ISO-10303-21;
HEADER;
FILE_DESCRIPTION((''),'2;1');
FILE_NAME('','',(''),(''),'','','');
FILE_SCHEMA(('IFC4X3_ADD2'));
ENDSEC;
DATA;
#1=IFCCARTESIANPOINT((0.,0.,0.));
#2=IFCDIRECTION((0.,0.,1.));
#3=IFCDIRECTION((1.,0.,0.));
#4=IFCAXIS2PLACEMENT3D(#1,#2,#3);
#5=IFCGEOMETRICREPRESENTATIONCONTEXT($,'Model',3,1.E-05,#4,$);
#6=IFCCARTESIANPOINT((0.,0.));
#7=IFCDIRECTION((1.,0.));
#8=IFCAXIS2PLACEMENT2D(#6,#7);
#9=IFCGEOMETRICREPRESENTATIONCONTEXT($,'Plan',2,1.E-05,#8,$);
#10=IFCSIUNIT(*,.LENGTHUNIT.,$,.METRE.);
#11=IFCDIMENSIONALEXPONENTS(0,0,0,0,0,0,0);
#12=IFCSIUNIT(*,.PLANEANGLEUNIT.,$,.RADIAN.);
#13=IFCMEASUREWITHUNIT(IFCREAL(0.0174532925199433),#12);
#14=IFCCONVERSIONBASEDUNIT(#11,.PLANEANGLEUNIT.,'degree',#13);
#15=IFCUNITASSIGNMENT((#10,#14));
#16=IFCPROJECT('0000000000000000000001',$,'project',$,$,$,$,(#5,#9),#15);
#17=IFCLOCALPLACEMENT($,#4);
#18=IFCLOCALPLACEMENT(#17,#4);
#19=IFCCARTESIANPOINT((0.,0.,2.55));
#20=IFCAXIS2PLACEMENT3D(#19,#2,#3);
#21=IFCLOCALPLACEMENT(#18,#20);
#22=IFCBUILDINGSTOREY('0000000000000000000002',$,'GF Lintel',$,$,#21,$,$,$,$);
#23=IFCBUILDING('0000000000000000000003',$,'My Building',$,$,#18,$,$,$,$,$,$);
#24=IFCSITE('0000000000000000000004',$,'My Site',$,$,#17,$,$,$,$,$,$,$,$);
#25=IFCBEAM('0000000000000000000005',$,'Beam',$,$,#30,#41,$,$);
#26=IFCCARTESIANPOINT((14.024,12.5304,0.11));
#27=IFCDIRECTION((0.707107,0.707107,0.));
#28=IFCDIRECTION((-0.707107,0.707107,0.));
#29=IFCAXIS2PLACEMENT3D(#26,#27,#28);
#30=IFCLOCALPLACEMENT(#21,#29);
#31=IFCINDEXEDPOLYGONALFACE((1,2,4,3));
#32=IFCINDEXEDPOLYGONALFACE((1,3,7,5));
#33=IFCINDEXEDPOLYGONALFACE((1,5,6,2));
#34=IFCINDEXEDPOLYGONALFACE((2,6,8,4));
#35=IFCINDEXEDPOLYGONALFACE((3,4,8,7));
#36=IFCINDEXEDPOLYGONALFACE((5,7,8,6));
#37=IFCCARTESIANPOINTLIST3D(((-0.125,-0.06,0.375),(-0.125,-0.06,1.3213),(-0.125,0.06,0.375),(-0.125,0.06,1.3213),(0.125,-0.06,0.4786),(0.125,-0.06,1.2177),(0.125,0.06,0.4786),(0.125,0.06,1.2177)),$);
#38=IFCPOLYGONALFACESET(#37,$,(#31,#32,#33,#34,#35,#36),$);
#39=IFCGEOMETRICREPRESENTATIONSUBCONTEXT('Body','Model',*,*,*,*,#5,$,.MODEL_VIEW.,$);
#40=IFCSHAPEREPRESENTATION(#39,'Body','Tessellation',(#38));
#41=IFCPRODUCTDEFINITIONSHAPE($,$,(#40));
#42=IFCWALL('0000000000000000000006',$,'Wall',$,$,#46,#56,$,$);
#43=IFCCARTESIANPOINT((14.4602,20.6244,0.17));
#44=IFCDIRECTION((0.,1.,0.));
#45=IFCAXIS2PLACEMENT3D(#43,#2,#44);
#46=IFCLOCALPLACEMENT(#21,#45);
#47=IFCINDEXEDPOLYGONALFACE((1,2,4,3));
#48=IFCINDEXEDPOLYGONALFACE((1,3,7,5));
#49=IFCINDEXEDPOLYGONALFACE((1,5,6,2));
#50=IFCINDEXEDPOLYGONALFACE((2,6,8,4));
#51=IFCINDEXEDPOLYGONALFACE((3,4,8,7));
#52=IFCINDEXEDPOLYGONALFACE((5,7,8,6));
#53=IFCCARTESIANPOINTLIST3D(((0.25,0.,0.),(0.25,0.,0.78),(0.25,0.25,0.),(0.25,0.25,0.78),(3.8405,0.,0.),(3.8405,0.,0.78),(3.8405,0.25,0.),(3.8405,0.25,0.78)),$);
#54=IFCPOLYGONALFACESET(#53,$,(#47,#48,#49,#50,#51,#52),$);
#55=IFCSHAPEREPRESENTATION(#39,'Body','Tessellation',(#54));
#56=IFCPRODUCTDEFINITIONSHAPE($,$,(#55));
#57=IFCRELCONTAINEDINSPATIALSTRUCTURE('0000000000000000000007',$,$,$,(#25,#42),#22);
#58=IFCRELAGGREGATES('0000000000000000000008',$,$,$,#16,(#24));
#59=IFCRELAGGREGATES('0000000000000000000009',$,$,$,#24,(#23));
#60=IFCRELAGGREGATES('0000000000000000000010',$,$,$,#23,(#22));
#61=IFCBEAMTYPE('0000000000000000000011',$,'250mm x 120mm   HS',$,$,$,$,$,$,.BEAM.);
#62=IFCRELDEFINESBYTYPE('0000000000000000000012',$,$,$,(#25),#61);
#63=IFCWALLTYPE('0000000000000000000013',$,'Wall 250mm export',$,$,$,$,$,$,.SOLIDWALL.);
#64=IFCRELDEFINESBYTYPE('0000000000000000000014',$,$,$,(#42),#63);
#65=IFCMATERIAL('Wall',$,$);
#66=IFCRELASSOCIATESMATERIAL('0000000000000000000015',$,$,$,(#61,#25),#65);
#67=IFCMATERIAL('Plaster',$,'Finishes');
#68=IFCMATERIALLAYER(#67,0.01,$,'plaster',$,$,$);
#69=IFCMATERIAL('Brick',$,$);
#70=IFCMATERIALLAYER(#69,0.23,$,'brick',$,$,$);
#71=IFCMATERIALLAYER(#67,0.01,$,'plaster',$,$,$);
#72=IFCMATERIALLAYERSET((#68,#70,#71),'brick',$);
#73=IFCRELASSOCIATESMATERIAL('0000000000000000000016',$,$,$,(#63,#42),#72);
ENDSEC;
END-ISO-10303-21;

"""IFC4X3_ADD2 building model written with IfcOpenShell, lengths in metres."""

from ifc_helpers import new_model, entity, si_unit, converted_unit, frame, origin_with_axes, origin_2d_with_axis, place, context, subcontext, project, spatial, line, indexed_curve, rectangle, outline, extrude, clip, halfspace, material, layer, layer_set, layer_usage, material_profile, profile_set, profile_usage, type_object, element, save


model = new_model("IFC4X3_ADD2")

# Units and contexts
model_context = context("Model", 3, precision=1e-05, world=origin_with_axes())
plan_context = context("Plan", 2, precision=1e-05, world=origin_2d_with_axis())
body_context = subcontext(model_context, "Body", "Model", "MODEL_VIEW")
ifc_project = project(units=[si_unit("LENGTHUNIT", "METRE"), converted_unit("PLANEANGLEUNIT", "degree", entity("IfcReal", 0.0174532925199433), si_unit("PLANEANGLEUNIT", "RADIAN"), dimensions=[0, 0, 0, 0, 0, 0, 0])], contexts=[model_context, plan_context])

# Site, building, storey
site_placement = place(None, origin_with_axes())
site = spatial("IfcSite", under=ifc_project, at=site_placement, Name="My Site")
building_placement = place(site_placement, origin_with_axes())
building = spatial("IfcBuilding", under=site, at=building_placement, Name="My Building")
storey_placement = place(building_placement, frame((0.0, 0.0, 2.55), z_axis=(0.0, 0.0, 1.0), x_axis=(1.0, 0.0, 0.0)))
storey = spatial("IfcBuildingStorey", under=building, at=storey_placement, Name="GF Lintel")

# Beam
ifc_material_1 = material(Name="Wall")
ifc_material_profile = material_profile(ifc_material_1, rectangle(XDim=0.25, YDim=0.12))
ifc_profile_set = profile_set([ifc_material_profile], Name="concrete")
beam_type = type_object("IfcBeamType", Name="250mm x 120mm   HS", PredefinedType="BEAM", material=ifc_profile_set)
ifc_profile_usage_1 = profile_usage(ifc_profile_set, cardinal=5)
beam_1_placement = place(storey_placement, frame((14.024, 12.5304, 0.11), z_axis=(0.707107, 0.707107, 0.0), x_axis=(-0.707107, 0.707107, 0.0)))
element("IfcBeam", 1, at=beam_1_placement, inside=storey, type_object=beam_type, material=ifc_profile_usage_1, Name="Beam", context=body_context, shape_type="Clipping", body=[
    clip(clip(extrude(rectangle(XDim=0.25, YDim=0.12), origin_with_axes(), (0.0, 0.0, 1.0), 1.6963), halfspace(frame((-0.125, -2.66, 1.3213), z_axis=(0.382685, 0.0, 0.923879), x_axis=(0.0, -1.0, 0.0)), False)), halfspace(frame((-0.125, -2.66, 0.375), z_axis=(0.382682, 0.0, -0.92388), x_axis=(0.0, -1.0, 0.0)), False)),
])

# Wall
ifc_material_2 = material(Name="Plaster", Category="Finishes")
ifc_layer_1 = layer(ifc_material_2, 0.01, Name="plaster")
ifc_material_3 = material(Name="Brick")
ifc_layer_2 = layer(ifc_material_3, 0.23, Name="brick")
ifc_layer_3 = layer(ifc_material_2, 0.01, Name="plaster")
ifc_layer_set = layer_set([ifc_layer_1, ifc_layer_2, ifc_layer_3], Name="brick")
wall_type = type_object("IfcWallType", Name="Wall 250mm export", PredefinedType="SOLIDWALL", material=ifc_layer_set)
ifc_layer_usage_1 = layer_usage(ifc_layer_set, "AXIS2", "POSITIVE", 0.0)
wall_1_placement = place(storey_placement, frame((14.4602, 20.6244, 0.17), z_axis=(0.0, 0.0, 1.0), x_axis=(0.0, 1.0, 0.0)))
element("IfcWall", 2, at=wall_1_placement, inside=storey, type_object=wall_type, material=ifc_layer_usage_1, Name="Wall", context=body_context, shape_type="SweptSolid", body=[
    extrude(outline(indexed_curve([(0.25, 0.0), (0.25, 0.25), (3.8405, 0.25), (3.8405, 0.0)], segments=[line(1, 2, 3, 4, 1)])), origin_with_axes(), (0.0, 0.0, 1.0), 0.78),
])

save(model, "model.ifc")
